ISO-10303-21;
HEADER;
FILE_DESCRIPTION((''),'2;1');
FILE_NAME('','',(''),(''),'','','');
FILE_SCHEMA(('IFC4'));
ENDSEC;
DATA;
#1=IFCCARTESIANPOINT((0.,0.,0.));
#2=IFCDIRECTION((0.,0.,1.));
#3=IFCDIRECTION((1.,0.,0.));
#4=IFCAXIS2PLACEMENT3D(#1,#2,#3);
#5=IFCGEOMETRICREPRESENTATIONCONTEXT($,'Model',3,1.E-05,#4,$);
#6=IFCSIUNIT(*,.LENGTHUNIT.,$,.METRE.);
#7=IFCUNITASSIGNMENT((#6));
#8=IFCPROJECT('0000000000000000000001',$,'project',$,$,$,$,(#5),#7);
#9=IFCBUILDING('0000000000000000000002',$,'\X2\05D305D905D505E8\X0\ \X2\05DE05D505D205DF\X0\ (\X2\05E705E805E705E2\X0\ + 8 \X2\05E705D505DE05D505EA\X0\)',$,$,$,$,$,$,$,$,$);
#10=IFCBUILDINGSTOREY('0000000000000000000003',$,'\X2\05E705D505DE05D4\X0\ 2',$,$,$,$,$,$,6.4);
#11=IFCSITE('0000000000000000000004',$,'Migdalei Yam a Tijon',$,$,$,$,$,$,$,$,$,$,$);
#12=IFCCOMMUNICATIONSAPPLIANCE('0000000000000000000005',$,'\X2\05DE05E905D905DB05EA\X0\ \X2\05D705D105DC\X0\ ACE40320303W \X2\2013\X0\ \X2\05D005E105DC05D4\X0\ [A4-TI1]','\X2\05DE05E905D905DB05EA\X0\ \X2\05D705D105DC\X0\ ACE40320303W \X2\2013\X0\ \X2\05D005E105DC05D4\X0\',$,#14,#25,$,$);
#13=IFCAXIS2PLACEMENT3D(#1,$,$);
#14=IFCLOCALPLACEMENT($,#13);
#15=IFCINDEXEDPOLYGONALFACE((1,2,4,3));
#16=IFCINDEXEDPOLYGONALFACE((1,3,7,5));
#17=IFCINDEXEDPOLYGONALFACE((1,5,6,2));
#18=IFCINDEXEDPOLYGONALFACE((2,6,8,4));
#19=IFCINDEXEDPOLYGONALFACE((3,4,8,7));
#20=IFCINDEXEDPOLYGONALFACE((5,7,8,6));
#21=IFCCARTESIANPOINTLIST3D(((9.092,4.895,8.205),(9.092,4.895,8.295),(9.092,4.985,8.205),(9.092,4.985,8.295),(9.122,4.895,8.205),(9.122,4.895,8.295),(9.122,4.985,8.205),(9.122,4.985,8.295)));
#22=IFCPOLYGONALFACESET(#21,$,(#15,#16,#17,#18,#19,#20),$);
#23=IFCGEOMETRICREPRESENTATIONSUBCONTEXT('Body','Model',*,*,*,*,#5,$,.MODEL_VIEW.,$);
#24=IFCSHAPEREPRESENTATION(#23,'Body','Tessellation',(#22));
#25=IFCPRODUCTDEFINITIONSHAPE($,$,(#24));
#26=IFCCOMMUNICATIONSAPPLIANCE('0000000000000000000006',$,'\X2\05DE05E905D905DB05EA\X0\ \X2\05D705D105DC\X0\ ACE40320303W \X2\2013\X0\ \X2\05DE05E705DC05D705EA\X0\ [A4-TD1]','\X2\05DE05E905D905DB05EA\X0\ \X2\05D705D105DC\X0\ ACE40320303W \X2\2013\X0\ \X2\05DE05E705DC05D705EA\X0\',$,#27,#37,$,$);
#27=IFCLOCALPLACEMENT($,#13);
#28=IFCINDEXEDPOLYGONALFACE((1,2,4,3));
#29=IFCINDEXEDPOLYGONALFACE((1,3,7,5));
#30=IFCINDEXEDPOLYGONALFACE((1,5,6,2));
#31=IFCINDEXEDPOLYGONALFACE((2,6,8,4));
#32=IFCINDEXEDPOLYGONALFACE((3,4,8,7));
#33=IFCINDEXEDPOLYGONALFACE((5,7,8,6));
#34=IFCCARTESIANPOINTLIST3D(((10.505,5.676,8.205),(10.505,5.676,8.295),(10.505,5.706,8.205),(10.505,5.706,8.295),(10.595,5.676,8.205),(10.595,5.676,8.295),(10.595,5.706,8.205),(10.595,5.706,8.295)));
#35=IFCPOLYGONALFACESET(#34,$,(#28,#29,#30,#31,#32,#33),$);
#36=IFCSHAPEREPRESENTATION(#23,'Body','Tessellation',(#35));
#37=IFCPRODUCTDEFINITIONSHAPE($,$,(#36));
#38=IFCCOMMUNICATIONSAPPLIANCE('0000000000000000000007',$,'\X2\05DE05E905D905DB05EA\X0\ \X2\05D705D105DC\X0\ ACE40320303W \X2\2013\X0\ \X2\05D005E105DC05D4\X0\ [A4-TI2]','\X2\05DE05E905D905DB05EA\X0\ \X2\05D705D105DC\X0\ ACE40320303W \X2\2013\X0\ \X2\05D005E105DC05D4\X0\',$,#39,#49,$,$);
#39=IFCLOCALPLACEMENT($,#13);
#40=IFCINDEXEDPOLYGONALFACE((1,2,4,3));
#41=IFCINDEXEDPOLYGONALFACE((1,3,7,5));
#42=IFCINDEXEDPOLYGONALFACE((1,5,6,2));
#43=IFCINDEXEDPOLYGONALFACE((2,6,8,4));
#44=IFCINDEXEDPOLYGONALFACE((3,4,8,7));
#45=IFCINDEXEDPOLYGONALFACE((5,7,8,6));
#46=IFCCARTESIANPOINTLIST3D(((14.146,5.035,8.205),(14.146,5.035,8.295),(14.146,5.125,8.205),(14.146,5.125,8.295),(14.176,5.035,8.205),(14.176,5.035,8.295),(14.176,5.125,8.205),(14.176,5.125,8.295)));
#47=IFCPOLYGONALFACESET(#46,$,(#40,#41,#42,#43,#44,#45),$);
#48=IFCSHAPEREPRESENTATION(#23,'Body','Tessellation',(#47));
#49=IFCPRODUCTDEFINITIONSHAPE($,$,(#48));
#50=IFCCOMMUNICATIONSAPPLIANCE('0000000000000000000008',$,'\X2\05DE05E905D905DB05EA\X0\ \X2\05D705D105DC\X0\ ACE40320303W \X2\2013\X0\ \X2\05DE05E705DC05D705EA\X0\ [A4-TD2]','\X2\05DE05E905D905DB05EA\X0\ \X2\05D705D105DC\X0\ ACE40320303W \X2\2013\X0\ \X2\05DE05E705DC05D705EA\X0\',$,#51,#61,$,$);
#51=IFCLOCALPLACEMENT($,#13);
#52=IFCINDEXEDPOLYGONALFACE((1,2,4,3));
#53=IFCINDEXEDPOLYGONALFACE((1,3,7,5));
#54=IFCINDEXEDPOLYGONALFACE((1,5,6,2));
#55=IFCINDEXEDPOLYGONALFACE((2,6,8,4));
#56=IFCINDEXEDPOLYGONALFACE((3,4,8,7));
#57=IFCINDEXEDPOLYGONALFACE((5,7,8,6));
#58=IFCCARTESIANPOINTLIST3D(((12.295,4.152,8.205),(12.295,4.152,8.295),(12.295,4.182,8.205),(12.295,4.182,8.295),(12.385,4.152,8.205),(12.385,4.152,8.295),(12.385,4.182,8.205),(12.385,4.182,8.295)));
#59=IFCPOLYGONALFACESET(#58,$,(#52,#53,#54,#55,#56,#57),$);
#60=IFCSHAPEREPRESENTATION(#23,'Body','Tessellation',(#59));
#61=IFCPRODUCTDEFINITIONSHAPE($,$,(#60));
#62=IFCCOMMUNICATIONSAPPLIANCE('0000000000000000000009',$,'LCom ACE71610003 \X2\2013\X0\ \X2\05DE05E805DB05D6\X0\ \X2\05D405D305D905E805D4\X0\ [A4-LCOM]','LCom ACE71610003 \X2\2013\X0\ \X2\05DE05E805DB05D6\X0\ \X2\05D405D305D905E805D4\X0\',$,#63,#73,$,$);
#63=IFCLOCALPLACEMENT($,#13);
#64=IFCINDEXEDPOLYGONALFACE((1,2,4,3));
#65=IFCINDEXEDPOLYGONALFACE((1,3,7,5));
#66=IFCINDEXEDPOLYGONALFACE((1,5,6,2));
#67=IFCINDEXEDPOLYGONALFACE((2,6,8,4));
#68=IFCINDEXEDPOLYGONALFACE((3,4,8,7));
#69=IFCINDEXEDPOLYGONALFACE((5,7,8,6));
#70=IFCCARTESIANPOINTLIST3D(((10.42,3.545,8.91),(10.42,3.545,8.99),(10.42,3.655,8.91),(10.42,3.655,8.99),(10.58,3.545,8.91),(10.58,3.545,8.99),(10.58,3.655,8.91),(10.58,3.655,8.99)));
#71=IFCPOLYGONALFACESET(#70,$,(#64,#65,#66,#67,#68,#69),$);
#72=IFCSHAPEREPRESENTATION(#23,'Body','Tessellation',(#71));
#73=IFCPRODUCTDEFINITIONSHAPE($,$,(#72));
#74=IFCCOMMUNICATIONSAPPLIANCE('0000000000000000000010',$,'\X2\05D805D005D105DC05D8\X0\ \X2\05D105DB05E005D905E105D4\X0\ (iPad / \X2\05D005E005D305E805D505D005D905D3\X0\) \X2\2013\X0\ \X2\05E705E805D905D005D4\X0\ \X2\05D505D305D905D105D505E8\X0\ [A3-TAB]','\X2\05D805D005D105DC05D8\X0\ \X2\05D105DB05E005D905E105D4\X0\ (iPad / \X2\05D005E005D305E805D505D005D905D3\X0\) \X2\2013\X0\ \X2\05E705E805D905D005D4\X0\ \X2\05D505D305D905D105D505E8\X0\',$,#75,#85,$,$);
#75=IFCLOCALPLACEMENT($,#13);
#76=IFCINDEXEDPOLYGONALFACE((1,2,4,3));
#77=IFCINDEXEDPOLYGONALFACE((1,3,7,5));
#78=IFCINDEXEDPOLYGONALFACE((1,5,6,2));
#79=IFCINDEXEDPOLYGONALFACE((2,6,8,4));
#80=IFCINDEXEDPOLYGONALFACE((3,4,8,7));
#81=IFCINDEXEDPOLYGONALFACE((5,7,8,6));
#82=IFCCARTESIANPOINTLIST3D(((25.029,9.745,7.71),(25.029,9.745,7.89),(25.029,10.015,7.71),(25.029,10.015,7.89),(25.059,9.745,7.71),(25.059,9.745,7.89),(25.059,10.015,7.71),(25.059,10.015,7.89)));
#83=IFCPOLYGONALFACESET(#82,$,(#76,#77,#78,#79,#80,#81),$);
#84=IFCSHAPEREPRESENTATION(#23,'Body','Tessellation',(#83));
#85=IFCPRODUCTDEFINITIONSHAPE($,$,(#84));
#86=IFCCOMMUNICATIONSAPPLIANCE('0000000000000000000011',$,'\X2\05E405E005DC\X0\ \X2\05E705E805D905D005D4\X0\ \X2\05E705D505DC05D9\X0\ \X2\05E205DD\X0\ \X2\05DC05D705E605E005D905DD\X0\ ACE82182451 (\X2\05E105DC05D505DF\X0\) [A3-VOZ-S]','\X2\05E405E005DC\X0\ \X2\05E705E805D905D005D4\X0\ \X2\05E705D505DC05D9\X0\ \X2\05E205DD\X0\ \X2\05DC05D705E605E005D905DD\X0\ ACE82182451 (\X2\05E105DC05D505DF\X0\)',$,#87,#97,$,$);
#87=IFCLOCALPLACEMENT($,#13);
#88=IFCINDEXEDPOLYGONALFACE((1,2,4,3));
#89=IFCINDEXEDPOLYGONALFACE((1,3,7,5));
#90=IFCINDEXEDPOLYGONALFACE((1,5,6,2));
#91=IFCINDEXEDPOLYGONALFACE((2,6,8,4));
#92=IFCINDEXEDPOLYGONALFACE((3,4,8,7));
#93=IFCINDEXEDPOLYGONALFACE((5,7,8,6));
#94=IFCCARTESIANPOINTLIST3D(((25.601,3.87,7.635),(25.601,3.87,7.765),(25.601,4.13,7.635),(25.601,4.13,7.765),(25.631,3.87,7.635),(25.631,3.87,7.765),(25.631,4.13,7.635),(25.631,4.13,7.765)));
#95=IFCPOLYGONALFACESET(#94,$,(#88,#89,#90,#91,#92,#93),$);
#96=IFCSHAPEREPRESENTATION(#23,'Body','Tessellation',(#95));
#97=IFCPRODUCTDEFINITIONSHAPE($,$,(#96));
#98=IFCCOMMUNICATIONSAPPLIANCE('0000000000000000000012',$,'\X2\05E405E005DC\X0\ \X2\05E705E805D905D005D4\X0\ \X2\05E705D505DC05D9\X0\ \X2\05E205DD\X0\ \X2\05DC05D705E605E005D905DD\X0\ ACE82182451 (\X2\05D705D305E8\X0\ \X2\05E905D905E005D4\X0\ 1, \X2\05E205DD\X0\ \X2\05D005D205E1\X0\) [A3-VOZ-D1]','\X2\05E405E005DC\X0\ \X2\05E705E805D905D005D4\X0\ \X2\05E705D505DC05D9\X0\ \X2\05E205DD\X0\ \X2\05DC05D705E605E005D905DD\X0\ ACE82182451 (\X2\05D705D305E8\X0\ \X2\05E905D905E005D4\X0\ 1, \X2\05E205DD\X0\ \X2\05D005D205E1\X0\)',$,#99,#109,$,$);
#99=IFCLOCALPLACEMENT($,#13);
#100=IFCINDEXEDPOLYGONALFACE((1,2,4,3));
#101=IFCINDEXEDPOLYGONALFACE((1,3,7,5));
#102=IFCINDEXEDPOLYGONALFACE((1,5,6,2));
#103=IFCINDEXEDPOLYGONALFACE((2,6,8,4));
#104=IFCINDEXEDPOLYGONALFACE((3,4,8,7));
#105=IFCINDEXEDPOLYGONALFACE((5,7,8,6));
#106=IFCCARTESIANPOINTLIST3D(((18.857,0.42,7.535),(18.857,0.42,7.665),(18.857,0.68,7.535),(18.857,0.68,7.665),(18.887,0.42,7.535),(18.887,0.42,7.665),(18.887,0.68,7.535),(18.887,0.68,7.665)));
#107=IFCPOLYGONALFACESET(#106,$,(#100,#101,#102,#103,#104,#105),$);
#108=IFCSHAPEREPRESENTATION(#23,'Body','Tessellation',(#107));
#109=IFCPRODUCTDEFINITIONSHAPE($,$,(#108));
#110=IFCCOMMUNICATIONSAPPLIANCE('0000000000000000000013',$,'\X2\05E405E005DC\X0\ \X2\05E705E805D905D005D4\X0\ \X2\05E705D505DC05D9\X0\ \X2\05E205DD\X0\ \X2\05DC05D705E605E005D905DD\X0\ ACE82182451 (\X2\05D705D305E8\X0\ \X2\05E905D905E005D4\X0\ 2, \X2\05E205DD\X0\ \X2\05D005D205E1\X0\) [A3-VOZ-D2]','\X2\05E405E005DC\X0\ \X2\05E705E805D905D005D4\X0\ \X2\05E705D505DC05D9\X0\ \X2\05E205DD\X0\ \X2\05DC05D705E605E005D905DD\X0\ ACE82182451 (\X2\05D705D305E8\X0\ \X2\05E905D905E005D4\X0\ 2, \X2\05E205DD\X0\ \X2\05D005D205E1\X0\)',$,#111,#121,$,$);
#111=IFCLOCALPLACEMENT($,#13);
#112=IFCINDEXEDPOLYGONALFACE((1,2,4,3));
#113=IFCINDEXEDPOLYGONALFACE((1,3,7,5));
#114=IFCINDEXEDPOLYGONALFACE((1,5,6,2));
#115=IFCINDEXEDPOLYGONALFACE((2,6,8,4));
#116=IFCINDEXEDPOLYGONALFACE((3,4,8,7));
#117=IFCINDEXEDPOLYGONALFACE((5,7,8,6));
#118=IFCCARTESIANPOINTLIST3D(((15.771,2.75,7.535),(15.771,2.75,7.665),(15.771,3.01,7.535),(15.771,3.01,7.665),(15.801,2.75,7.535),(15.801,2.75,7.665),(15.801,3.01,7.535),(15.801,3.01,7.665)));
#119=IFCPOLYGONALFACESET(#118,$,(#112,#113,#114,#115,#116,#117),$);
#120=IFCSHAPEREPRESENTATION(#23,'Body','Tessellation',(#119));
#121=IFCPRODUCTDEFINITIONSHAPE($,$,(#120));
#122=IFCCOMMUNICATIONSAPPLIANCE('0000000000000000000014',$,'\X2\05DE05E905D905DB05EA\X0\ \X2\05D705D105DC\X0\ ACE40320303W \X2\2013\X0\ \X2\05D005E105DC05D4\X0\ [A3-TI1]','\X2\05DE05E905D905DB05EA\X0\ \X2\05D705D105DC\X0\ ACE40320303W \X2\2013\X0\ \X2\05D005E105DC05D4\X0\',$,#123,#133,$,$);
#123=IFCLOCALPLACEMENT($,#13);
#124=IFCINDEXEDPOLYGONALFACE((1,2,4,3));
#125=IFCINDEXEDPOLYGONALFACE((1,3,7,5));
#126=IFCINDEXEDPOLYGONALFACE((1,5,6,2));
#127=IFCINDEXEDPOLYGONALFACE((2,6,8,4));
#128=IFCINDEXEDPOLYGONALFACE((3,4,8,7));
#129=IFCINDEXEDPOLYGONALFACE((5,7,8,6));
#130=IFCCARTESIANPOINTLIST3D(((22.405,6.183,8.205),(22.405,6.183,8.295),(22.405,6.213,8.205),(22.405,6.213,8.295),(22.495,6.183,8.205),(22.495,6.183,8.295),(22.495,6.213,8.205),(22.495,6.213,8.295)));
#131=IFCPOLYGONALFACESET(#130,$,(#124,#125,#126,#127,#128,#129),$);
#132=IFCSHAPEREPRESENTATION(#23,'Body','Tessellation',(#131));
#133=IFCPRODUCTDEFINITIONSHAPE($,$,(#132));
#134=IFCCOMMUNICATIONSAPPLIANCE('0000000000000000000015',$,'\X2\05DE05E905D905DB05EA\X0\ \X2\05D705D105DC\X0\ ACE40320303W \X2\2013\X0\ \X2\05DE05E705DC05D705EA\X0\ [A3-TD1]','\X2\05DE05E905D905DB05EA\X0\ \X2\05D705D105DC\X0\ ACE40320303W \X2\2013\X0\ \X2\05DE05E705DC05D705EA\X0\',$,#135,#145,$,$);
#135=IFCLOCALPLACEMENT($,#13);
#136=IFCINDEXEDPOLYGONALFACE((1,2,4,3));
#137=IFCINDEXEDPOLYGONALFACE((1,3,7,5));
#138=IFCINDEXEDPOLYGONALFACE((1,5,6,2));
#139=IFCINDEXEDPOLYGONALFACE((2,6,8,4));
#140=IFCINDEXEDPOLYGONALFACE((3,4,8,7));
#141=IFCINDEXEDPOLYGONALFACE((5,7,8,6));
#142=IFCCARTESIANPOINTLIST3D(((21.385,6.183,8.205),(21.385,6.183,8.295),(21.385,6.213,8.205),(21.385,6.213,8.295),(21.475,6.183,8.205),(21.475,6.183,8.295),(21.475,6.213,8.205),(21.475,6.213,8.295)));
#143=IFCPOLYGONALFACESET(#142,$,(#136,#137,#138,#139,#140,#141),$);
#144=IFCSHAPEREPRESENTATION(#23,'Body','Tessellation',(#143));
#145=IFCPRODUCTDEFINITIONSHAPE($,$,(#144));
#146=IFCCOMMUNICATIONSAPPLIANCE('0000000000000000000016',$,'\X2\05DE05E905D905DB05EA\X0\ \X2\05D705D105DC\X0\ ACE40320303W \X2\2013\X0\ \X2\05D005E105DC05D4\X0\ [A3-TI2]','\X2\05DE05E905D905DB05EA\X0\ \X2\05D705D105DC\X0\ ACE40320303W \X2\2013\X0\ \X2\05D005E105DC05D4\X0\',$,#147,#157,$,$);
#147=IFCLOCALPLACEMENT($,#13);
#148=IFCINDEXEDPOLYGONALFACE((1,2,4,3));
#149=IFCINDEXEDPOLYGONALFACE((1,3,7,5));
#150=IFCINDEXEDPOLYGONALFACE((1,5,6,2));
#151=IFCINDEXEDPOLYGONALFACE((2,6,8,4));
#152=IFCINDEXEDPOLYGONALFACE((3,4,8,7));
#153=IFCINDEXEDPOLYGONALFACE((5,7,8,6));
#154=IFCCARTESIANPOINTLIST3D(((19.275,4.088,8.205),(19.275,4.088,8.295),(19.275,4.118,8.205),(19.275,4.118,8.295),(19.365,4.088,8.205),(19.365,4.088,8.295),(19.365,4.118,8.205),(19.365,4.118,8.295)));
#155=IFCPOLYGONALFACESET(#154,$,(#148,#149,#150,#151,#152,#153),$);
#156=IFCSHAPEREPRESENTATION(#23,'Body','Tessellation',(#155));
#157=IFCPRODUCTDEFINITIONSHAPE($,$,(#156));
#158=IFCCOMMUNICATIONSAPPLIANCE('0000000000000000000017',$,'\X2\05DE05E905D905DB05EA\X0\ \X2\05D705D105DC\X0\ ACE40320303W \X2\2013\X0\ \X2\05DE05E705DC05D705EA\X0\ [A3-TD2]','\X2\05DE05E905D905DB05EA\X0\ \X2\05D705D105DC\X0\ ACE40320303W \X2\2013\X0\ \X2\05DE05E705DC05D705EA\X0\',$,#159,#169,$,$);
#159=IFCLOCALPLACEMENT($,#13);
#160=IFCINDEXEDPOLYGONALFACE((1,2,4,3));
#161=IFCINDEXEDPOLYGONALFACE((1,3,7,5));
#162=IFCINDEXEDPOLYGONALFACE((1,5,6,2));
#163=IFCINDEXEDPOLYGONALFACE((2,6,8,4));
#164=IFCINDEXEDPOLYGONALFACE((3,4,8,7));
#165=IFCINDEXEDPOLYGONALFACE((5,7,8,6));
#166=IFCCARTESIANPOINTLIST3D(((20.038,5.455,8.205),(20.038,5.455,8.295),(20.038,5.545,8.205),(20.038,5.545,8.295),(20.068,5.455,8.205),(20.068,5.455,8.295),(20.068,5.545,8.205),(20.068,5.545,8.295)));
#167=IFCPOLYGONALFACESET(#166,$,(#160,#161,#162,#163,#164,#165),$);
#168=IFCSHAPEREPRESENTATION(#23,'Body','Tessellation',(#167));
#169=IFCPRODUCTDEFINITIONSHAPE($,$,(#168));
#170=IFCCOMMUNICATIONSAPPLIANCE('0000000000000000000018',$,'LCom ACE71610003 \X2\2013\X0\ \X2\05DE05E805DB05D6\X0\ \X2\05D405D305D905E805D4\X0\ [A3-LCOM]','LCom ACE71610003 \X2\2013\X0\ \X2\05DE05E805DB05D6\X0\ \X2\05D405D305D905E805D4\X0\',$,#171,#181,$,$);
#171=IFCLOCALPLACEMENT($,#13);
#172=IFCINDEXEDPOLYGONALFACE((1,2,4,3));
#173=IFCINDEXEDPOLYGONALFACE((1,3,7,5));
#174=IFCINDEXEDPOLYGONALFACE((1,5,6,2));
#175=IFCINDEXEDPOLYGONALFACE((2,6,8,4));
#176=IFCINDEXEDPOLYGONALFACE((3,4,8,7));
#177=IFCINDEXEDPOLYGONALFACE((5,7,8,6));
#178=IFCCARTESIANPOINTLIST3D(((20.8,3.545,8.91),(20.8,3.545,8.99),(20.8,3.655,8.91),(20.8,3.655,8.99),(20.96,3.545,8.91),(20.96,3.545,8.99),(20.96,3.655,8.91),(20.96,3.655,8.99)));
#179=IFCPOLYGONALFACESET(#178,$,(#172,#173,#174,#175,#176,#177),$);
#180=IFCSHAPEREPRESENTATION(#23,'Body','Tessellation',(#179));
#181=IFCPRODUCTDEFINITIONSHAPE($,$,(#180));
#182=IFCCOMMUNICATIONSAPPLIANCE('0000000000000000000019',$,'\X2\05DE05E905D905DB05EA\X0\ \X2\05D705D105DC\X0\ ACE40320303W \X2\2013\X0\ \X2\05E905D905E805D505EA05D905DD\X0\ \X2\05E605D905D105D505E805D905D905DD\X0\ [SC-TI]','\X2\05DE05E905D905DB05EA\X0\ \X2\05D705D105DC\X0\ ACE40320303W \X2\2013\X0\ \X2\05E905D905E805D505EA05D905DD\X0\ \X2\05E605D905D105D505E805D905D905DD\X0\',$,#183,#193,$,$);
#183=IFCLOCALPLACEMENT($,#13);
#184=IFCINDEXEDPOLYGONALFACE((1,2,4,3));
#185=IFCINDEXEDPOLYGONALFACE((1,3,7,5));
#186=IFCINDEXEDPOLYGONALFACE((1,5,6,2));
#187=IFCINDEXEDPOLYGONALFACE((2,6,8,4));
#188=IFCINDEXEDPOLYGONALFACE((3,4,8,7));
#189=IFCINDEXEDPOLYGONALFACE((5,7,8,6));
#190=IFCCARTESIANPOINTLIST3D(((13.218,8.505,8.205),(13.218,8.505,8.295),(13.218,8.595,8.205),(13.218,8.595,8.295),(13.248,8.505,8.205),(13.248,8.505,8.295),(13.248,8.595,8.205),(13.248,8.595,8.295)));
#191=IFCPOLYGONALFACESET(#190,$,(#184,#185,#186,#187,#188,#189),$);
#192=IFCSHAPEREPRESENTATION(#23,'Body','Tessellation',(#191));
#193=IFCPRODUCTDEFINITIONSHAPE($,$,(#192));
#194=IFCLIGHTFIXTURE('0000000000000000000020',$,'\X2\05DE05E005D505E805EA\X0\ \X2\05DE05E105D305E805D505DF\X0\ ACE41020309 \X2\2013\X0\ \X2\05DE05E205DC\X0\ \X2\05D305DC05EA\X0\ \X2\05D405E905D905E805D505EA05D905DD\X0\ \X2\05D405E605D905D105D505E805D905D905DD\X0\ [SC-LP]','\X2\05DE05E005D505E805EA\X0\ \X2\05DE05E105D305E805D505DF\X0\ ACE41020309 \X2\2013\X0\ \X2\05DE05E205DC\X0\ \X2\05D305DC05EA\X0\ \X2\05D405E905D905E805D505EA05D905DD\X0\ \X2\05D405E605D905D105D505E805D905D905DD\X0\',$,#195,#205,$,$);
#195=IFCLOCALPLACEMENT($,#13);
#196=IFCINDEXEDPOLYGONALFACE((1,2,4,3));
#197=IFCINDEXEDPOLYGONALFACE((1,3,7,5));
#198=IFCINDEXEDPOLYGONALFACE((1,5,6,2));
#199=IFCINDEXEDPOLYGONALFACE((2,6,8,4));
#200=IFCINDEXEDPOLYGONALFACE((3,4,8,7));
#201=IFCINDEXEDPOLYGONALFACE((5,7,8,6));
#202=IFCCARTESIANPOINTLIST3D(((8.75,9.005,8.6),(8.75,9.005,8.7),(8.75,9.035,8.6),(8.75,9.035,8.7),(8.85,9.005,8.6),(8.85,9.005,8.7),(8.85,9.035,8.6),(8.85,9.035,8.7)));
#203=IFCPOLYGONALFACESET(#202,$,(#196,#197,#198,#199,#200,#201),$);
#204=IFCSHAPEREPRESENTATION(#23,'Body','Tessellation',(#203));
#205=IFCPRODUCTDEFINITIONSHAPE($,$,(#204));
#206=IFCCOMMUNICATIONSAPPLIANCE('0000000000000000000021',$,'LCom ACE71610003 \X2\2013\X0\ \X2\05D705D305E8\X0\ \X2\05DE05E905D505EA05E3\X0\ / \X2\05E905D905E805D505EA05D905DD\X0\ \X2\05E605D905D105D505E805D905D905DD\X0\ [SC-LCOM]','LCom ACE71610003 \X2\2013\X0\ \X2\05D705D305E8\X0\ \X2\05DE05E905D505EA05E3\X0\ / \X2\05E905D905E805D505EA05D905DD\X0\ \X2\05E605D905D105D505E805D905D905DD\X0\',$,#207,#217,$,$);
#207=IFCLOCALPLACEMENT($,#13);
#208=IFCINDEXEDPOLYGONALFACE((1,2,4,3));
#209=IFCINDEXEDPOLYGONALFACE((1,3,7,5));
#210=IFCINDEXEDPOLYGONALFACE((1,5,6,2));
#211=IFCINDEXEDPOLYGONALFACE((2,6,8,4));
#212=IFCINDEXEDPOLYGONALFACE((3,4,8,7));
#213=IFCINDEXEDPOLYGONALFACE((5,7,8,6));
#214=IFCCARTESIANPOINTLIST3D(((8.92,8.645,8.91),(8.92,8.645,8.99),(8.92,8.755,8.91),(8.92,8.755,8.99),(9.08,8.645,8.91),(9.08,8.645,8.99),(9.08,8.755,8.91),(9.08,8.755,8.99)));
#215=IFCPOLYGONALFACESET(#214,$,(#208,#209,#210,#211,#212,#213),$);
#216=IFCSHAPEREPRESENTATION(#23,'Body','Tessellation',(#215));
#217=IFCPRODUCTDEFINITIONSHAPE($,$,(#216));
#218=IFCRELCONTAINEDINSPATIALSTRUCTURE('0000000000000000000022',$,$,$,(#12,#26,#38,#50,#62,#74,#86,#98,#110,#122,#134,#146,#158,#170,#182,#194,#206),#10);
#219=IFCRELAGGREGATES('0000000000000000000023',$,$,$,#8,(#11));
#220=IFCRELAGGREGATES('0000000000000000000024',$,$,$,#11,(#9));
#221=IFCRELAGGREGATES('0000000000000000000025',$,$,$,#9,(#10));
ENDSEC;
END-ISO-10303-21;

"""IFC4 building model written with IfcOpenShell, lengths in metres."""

from ifc_helpers import new_model, si_unit, frame, origin_with_axes, context, subcontext, project, spatial, line, indexed_curve, outline, extrude, element, save


model = new_model("IFC4")

# Units and contexts
model_context = context("Model", 3, precision=1e-05, world=origin_with_axes())
body_context = subcontext(model_context, "Body", "Model", "MODEL_VIEW")
ifc_project = project(units=[si_unit("LENGTHUNIT", "METRE")], contexts=[model_context])

# Site, building, storey
site = spatial("IfcSite", under=ifc_project, Name="Migdalei Yam a Tijon")
building = spatial("IfcBuilding", under=site, Name="דיור מוגן (קרקע + 8 קומות)")
storey = spatial("IfcBuildingStorey", under=building, Name="קומה 2", Elevation=6.4)

# Communications appliances
element("IfcCommunicationsAppliance", 1, inside=storey, Name="משיכת חבל ACE40320303W – אסלה [A4-TI1]", Description="משיכת חבל ACE40320303W – אסלה", context=body_context, shape_type="SweptSolid", body=[
    extrude(outline(indexed_curve([(0.0, 0.0), (0.03, 0.0), (0.03, 0.09), (0.0, 0.09)], segments=[line(1, 2, 3, 4, 1)])), frame((9.092, 4.895, 8.205), z_axis=(0.0, 0.0, 1.0), x_axis=(1.0, 0.0, 0.0)), (0.0, 0.0, 1.0), 0.09),
])
element("IfcCommunicationsAppliance", 2, inside=storey, Name="משיכת חבל ACE40320303W – מקלחת [A4-TD1]", Description="משיכת חבל ACE40320303W – מקלחת", context=body_context, shape_type="SweptSolid", body=[
    extrude(outline(indexed_curve([(0.0, 0.0), (0.09, 0.0), (0.09, 0.03), (0.0, 0.03)], segments=[line(1, 2, 3, 4, 1)])), frame((10.505, 5.676, 8.205), z_axis=(0.0, 0.0, 1.0), x_axis=(1.0, 0.0, 0.0)), (0.0, 0.0, 1.0), 0.09),
])
element("IfcCommunicationsAppliance", 3, inside=storey, Name="משיכת חבל ACE40320303W – אסלה [A4-TI2]", Description="משיכת חבל ACE40320303W – אסלה", context=body_context, shape_type="SweptSolid", body=[
    extrude(outline(indexed_curve([(0.0, 0.0), (0.03, 0.0), (0.03, 0.09), (0.0, 0.09)], segments=[line(1, 2, 3, 4, 1)])), frame((14.146, 5.035, 8.205), z_axis=(0.0, 0.0, 1.0), x_axis=(1.0, 0.0, 0.0)), (0.0, 0.0, 1.0), 0.09),
])
element("IfcCommunicationsAppliance", 4, inside=storey, Name="משיכת חבל ACE40320303W – מקלחת [A4-TD2]", Description="משיכת חבל ACE40320303W – מקלחת", context=body_context, shape_type="SweptSolid", body=[
    extrude(outline(indexed_curve([(0.0, 0.0), (0.09, 0.0), (0.09, 0.03), (0.0, 0.03)], segments=[line(1, 2, 3, 4, 1)])), frame((12.295, 4.152, 8.205), z_axis=(0.0, 0.0, 1.0), x_axis=(1.0, 0.0, 0.0)), (0.0, 0.0, 1.0), 0.09),
])
element("IfcCommunicationsAppliance", 5, inside=storey, Name="LCom ACE71610003 – מרכז הדירה [A4-LCOM]", Description="LCom ACE71610003 – מרכז הדירה", context=body_context, shape_type="SweptSolid", body=[
    extrude(outline(indexed_curve([(0.0, 0.0), (0.16, 0.0), (0.16, 0.11), (0.0, 0.11)], segments=[line(1, 2, 3, 4, 1)])), frame((10.42, 3.545, 8.91), z_axis=(0.0, 0.0, 1.0), x_axis=(1.0, 0.0, 0.0)), (0.0, 0.0, 1.0), 0.08),
])
element("IfcCommunicationsAppliance", 6, inside=storey, Name="טאבלט בכניסה (iPad / אנדרואיד) – קריאה ודיבור [A3-TAB]", Description="טאבלט בכניסה (iPad / אנדרואיד) – קריאה ודיבור", context=body_context, shape_type="SweptSolid", body=[
    extrude(outline(indexed_curve([(0.0, 0.0), (0.03, 0.0), (0.03, 0.27), (0.0, 0.27)], segments=[line(1, 2, 3, 4, 1)])), frame((25.029, 9.745, 7.71), z_axis=(0.0, 0.0, 1.0), x_axis=(1.0, 0.0, 0.0)), (0.0, 0.0, 1.0), 0.18),
])
element("IfcCommunicationsAppliance", 7, inside=storey, Name="פנל קריאה קולי עם לחצנים ACE82182451 (סלון) [A3-VOZ-S]", Description="פנל קריאה קולי עם לחצנים ACE82182451 (סלון)", context=body_context, shape_type="SweptSolid", body=[
    extrude(outline(indexed_curve([(0.0, 0.0), (0.03, 0.0), (0.03, 0.26), (0.0, 0.26)], segments=[line(1, 2, 3, 4, 1)])), frame((25.601, 3.87, 7.635), z_axis=(0.0, 0.0, 1.0), x_axis=(1.0, 0.0, 0.0)), (0.0, 0.0, 1.0), 0.13),
])
element("IfcCommunicationsAppliance", 8, inside=storey, Name="פנל קריאה קולי עם לחצנים ACE82182451 (חדר שינה 1, עם אגס) [A3-VOZ-D1]", Description="פנל קריאה קולי עם לחצנים ACE82182451 (חדר שינה 1, עם אגס)", context=body_context, shape_type="SweptSolid", body=[
    extrude(outline(indexed_curve([(0.0, 0.0), (0.03, 0.0), (0.03, 0.26), (0.0, 0.26)], segments=[line(1, 2, 3, 4, 1)])), frame((18.857, 0.42, 7.535), z_axis=(0.0, 0.0, 1.0), x_axis=(1.0, 0.0, 0.0)), (0.0, 0.0, 1.0), 0.13),
])
element("IfcCommunicationsAppliance", 9, inside=storey, Name="פנל קריאה קולי עם לחצנים ACE82182451 (חדר שינה 2, עם אגס) [A3-VOZ-D2]", Description="פנל קריאה קולי עם לחצנים ACE82182451 (חדר שינה 2, עם אגס)", context=body_context, shape_type="SweptSolid", body=[
    extrude(outline(indexed_curve([(0.0, 0.0), (0.03, 0.0), (0.03, 0.26), (0.0, 0.26)], segments=[line(1, 2, 3, 4, 1)])), frame((15.771, 2.75, 7.535), z_axis=(0.0, 0.0, 1.0), x_axis=(1.0, 0.0, 0.0)), (0.0, 0.0, 1.0), 0.13),
])
element("IfcCommunicationsAppliance", 10, inside=storey, Name="משיכת חבל ACE40320303W – אסלה [A3-TI1]", Description="משיכת חבל ACE40320303W – אסלה", context=body_context, shape_type="SweptSolid", body=[
    extrude(outline(indexed_curve([(0.0, 0.0), (0.09, 0.0), (0.09, 0.03), (0.0, 0.03)], segments=[line(1, 2, 3, 4, 1)])), frame((22.405, 6.183, 8.205), z_axis=(0.0, 0.0, 1.0), x_axis=(1.0, 0.0, 0.0)), (0.0, 0.0, 1.0), 0.09),
])
element("IfcCommunicationsAppliance", 11, inside=storey, Name="משיכת חבל ACE40320303W – מקלחת [A3-TD1]", Description="משיכת חבל ACE40320303W – מקלחת", context=body_context, shape_type="SweptSolid", body=[
    extrude(outline(indexed_curve([(0.0, 0.0), (0.09, 0.0), (0.09, 0.03), (0.0, 0.03)], segments=[line(1, 2, 3, 4, 1)])), frame((21.385, 6.183, 8.205), z_axis=(0.0, 0.0, 1.0), x_axis=(1.0, 0.0, 0.0)), (0.0, 0.0, 1.0), 0.09),
])
element("IfcCommunicationsAppliance", 12, inside=storey, Name="משיכת חבל ACE40320303W – אסלה [A3-TI2]", Description="משיכת חבל ACE40320303W – אסלה", context=body_context, shape_type="SweptSolid", body=[
    extrude(outline(indexed_curve([(0.0, 0.0), (0.09, 0.0), (0.09, 0.03), (0.0, 0.03)], segments=[line(1, 2, 3, 4, 1)])), frame((19.275, 4.088, 8.205), z_axis=(0.0, 0.0, 1.0), x_axis=(1.0, 0.0, 0.0)), (0.0, 0.0, 1.0), 0.09),
])
element("IfcCommunicationsAppliance", 13, inside=storey, Name="משיכת חבל ACE40320303W – מקלחת [A3-TD2]", Description="משיכת חבל ACE40320303W – מקלחת", context=body_context, shape_type="SweptSolid", body=[
    extrude(outline(indexed_curve([(0.0, 0.0), (0.03, 0.0), (0.03, 0.09), (0.0, 0.09)], segments=[line(1, 2, 3, 4, 1)])), frame((20.038, 5.455, 8.205), z_axis=(0.0, 0.0, 1.0), x_axis=(1.0, 0.0, 0.0)), (0.0, 0.0, 1.0), 0.09),
])
element("IfcCommunicationsAppliance", 14, inside=storey, Name="LCom ACE71610003 – מרכז הדירה [A3-LCOM]", Description="LCom ACE71610003 – מרכז הדירה", context=body_context, shape_type="SweptSolid", body=[
    extrude(outline(indexed_curve([(0.0, 0.0), (0.16, 0.0), (0.16, 0.11), (0.0, 0.11)], segments=[line(1, 2, 3, 4, 1)])), frame((20.8, 3.545, 8.91), z_axis=(0.0, 0.0, 1.0), x_axis=(1.0, 0.0, 0.0)), (0.0, 0.0, 1.0), 0.08),
])
element("IfcCommunicationsAppliance", 15, inside=storey, Name="משיכת חבל ACE40320303W – שירותים ציבוריים [SC-TI]", Description="משיכת חבל ACE40320303W – שירותים ציבוריים", context=body_context, shape_type="SweptSolid", body=[
    extrude(outline(indexed_curve([(0.0, 0.0), (0.03, 0.0), (0.03, 0.09), (0.0, 0.09)], segments=[line(1, 2, 3, 4, 1)])), frame((13.218, 8.505, 8.205), z_axis=(0.0, 0.0, 1.0), x_axis=(1.0, 0.0, 0.0)), (0.0, 0.0, 1.0), 0.09),
])

# Light fixture
element("IfcLightFixture", 16, inside=storey, Name="מנורת מסדרון ACE41020309 – מעל דלת השירותים הציבוריים [SC-LP]", Description="מנורת מסדרון ACE41020309 – מעל דלת השירותים הציבוריים", context=body_context, shape_type="SweptSolid", body=[
    extrude(outline(indexed_curve([(0.0, 0.0), (0.1, 0.0), (0.1, 0.03), (0.0, 0.03)], segments=[line(1, 2, 3, 4, 1)])), frame((8.75, 9.005, 8.6), z_axis=(0.0, 0.0, 1.0), x_axis=(1.0, 0.0, 0.0)), (0.0, 0.0, 1.0), 0.1),
])

# Communications appliance
element("IfcCommunicationsAppliance", 17, inside=storey, Name="LCom ACE71610003 – חדר משותף / שירותים ציבוריים [SC-LCOM]", Description="LCom ACE71610003 – חדר משותף / שירותים ציבוריים", context=body_context, shape_type="SweptSolid", body=[
    extrude(outline(indexed_curve([(0.0, 0.0), (0.16, 0.0), (0.16, 0.11), (0.0, 0.11)], segments=[line(1, 2, 3, 4, 1)])), frame((8.92, 8.645, 8.91), z_axis=(0.0, 0.0, 1.0), x_axis=(1.0, 0.0, 0.0)), (0.0, 0.0, 1.0), 0.08),
])

save(model, "model.ifc")
